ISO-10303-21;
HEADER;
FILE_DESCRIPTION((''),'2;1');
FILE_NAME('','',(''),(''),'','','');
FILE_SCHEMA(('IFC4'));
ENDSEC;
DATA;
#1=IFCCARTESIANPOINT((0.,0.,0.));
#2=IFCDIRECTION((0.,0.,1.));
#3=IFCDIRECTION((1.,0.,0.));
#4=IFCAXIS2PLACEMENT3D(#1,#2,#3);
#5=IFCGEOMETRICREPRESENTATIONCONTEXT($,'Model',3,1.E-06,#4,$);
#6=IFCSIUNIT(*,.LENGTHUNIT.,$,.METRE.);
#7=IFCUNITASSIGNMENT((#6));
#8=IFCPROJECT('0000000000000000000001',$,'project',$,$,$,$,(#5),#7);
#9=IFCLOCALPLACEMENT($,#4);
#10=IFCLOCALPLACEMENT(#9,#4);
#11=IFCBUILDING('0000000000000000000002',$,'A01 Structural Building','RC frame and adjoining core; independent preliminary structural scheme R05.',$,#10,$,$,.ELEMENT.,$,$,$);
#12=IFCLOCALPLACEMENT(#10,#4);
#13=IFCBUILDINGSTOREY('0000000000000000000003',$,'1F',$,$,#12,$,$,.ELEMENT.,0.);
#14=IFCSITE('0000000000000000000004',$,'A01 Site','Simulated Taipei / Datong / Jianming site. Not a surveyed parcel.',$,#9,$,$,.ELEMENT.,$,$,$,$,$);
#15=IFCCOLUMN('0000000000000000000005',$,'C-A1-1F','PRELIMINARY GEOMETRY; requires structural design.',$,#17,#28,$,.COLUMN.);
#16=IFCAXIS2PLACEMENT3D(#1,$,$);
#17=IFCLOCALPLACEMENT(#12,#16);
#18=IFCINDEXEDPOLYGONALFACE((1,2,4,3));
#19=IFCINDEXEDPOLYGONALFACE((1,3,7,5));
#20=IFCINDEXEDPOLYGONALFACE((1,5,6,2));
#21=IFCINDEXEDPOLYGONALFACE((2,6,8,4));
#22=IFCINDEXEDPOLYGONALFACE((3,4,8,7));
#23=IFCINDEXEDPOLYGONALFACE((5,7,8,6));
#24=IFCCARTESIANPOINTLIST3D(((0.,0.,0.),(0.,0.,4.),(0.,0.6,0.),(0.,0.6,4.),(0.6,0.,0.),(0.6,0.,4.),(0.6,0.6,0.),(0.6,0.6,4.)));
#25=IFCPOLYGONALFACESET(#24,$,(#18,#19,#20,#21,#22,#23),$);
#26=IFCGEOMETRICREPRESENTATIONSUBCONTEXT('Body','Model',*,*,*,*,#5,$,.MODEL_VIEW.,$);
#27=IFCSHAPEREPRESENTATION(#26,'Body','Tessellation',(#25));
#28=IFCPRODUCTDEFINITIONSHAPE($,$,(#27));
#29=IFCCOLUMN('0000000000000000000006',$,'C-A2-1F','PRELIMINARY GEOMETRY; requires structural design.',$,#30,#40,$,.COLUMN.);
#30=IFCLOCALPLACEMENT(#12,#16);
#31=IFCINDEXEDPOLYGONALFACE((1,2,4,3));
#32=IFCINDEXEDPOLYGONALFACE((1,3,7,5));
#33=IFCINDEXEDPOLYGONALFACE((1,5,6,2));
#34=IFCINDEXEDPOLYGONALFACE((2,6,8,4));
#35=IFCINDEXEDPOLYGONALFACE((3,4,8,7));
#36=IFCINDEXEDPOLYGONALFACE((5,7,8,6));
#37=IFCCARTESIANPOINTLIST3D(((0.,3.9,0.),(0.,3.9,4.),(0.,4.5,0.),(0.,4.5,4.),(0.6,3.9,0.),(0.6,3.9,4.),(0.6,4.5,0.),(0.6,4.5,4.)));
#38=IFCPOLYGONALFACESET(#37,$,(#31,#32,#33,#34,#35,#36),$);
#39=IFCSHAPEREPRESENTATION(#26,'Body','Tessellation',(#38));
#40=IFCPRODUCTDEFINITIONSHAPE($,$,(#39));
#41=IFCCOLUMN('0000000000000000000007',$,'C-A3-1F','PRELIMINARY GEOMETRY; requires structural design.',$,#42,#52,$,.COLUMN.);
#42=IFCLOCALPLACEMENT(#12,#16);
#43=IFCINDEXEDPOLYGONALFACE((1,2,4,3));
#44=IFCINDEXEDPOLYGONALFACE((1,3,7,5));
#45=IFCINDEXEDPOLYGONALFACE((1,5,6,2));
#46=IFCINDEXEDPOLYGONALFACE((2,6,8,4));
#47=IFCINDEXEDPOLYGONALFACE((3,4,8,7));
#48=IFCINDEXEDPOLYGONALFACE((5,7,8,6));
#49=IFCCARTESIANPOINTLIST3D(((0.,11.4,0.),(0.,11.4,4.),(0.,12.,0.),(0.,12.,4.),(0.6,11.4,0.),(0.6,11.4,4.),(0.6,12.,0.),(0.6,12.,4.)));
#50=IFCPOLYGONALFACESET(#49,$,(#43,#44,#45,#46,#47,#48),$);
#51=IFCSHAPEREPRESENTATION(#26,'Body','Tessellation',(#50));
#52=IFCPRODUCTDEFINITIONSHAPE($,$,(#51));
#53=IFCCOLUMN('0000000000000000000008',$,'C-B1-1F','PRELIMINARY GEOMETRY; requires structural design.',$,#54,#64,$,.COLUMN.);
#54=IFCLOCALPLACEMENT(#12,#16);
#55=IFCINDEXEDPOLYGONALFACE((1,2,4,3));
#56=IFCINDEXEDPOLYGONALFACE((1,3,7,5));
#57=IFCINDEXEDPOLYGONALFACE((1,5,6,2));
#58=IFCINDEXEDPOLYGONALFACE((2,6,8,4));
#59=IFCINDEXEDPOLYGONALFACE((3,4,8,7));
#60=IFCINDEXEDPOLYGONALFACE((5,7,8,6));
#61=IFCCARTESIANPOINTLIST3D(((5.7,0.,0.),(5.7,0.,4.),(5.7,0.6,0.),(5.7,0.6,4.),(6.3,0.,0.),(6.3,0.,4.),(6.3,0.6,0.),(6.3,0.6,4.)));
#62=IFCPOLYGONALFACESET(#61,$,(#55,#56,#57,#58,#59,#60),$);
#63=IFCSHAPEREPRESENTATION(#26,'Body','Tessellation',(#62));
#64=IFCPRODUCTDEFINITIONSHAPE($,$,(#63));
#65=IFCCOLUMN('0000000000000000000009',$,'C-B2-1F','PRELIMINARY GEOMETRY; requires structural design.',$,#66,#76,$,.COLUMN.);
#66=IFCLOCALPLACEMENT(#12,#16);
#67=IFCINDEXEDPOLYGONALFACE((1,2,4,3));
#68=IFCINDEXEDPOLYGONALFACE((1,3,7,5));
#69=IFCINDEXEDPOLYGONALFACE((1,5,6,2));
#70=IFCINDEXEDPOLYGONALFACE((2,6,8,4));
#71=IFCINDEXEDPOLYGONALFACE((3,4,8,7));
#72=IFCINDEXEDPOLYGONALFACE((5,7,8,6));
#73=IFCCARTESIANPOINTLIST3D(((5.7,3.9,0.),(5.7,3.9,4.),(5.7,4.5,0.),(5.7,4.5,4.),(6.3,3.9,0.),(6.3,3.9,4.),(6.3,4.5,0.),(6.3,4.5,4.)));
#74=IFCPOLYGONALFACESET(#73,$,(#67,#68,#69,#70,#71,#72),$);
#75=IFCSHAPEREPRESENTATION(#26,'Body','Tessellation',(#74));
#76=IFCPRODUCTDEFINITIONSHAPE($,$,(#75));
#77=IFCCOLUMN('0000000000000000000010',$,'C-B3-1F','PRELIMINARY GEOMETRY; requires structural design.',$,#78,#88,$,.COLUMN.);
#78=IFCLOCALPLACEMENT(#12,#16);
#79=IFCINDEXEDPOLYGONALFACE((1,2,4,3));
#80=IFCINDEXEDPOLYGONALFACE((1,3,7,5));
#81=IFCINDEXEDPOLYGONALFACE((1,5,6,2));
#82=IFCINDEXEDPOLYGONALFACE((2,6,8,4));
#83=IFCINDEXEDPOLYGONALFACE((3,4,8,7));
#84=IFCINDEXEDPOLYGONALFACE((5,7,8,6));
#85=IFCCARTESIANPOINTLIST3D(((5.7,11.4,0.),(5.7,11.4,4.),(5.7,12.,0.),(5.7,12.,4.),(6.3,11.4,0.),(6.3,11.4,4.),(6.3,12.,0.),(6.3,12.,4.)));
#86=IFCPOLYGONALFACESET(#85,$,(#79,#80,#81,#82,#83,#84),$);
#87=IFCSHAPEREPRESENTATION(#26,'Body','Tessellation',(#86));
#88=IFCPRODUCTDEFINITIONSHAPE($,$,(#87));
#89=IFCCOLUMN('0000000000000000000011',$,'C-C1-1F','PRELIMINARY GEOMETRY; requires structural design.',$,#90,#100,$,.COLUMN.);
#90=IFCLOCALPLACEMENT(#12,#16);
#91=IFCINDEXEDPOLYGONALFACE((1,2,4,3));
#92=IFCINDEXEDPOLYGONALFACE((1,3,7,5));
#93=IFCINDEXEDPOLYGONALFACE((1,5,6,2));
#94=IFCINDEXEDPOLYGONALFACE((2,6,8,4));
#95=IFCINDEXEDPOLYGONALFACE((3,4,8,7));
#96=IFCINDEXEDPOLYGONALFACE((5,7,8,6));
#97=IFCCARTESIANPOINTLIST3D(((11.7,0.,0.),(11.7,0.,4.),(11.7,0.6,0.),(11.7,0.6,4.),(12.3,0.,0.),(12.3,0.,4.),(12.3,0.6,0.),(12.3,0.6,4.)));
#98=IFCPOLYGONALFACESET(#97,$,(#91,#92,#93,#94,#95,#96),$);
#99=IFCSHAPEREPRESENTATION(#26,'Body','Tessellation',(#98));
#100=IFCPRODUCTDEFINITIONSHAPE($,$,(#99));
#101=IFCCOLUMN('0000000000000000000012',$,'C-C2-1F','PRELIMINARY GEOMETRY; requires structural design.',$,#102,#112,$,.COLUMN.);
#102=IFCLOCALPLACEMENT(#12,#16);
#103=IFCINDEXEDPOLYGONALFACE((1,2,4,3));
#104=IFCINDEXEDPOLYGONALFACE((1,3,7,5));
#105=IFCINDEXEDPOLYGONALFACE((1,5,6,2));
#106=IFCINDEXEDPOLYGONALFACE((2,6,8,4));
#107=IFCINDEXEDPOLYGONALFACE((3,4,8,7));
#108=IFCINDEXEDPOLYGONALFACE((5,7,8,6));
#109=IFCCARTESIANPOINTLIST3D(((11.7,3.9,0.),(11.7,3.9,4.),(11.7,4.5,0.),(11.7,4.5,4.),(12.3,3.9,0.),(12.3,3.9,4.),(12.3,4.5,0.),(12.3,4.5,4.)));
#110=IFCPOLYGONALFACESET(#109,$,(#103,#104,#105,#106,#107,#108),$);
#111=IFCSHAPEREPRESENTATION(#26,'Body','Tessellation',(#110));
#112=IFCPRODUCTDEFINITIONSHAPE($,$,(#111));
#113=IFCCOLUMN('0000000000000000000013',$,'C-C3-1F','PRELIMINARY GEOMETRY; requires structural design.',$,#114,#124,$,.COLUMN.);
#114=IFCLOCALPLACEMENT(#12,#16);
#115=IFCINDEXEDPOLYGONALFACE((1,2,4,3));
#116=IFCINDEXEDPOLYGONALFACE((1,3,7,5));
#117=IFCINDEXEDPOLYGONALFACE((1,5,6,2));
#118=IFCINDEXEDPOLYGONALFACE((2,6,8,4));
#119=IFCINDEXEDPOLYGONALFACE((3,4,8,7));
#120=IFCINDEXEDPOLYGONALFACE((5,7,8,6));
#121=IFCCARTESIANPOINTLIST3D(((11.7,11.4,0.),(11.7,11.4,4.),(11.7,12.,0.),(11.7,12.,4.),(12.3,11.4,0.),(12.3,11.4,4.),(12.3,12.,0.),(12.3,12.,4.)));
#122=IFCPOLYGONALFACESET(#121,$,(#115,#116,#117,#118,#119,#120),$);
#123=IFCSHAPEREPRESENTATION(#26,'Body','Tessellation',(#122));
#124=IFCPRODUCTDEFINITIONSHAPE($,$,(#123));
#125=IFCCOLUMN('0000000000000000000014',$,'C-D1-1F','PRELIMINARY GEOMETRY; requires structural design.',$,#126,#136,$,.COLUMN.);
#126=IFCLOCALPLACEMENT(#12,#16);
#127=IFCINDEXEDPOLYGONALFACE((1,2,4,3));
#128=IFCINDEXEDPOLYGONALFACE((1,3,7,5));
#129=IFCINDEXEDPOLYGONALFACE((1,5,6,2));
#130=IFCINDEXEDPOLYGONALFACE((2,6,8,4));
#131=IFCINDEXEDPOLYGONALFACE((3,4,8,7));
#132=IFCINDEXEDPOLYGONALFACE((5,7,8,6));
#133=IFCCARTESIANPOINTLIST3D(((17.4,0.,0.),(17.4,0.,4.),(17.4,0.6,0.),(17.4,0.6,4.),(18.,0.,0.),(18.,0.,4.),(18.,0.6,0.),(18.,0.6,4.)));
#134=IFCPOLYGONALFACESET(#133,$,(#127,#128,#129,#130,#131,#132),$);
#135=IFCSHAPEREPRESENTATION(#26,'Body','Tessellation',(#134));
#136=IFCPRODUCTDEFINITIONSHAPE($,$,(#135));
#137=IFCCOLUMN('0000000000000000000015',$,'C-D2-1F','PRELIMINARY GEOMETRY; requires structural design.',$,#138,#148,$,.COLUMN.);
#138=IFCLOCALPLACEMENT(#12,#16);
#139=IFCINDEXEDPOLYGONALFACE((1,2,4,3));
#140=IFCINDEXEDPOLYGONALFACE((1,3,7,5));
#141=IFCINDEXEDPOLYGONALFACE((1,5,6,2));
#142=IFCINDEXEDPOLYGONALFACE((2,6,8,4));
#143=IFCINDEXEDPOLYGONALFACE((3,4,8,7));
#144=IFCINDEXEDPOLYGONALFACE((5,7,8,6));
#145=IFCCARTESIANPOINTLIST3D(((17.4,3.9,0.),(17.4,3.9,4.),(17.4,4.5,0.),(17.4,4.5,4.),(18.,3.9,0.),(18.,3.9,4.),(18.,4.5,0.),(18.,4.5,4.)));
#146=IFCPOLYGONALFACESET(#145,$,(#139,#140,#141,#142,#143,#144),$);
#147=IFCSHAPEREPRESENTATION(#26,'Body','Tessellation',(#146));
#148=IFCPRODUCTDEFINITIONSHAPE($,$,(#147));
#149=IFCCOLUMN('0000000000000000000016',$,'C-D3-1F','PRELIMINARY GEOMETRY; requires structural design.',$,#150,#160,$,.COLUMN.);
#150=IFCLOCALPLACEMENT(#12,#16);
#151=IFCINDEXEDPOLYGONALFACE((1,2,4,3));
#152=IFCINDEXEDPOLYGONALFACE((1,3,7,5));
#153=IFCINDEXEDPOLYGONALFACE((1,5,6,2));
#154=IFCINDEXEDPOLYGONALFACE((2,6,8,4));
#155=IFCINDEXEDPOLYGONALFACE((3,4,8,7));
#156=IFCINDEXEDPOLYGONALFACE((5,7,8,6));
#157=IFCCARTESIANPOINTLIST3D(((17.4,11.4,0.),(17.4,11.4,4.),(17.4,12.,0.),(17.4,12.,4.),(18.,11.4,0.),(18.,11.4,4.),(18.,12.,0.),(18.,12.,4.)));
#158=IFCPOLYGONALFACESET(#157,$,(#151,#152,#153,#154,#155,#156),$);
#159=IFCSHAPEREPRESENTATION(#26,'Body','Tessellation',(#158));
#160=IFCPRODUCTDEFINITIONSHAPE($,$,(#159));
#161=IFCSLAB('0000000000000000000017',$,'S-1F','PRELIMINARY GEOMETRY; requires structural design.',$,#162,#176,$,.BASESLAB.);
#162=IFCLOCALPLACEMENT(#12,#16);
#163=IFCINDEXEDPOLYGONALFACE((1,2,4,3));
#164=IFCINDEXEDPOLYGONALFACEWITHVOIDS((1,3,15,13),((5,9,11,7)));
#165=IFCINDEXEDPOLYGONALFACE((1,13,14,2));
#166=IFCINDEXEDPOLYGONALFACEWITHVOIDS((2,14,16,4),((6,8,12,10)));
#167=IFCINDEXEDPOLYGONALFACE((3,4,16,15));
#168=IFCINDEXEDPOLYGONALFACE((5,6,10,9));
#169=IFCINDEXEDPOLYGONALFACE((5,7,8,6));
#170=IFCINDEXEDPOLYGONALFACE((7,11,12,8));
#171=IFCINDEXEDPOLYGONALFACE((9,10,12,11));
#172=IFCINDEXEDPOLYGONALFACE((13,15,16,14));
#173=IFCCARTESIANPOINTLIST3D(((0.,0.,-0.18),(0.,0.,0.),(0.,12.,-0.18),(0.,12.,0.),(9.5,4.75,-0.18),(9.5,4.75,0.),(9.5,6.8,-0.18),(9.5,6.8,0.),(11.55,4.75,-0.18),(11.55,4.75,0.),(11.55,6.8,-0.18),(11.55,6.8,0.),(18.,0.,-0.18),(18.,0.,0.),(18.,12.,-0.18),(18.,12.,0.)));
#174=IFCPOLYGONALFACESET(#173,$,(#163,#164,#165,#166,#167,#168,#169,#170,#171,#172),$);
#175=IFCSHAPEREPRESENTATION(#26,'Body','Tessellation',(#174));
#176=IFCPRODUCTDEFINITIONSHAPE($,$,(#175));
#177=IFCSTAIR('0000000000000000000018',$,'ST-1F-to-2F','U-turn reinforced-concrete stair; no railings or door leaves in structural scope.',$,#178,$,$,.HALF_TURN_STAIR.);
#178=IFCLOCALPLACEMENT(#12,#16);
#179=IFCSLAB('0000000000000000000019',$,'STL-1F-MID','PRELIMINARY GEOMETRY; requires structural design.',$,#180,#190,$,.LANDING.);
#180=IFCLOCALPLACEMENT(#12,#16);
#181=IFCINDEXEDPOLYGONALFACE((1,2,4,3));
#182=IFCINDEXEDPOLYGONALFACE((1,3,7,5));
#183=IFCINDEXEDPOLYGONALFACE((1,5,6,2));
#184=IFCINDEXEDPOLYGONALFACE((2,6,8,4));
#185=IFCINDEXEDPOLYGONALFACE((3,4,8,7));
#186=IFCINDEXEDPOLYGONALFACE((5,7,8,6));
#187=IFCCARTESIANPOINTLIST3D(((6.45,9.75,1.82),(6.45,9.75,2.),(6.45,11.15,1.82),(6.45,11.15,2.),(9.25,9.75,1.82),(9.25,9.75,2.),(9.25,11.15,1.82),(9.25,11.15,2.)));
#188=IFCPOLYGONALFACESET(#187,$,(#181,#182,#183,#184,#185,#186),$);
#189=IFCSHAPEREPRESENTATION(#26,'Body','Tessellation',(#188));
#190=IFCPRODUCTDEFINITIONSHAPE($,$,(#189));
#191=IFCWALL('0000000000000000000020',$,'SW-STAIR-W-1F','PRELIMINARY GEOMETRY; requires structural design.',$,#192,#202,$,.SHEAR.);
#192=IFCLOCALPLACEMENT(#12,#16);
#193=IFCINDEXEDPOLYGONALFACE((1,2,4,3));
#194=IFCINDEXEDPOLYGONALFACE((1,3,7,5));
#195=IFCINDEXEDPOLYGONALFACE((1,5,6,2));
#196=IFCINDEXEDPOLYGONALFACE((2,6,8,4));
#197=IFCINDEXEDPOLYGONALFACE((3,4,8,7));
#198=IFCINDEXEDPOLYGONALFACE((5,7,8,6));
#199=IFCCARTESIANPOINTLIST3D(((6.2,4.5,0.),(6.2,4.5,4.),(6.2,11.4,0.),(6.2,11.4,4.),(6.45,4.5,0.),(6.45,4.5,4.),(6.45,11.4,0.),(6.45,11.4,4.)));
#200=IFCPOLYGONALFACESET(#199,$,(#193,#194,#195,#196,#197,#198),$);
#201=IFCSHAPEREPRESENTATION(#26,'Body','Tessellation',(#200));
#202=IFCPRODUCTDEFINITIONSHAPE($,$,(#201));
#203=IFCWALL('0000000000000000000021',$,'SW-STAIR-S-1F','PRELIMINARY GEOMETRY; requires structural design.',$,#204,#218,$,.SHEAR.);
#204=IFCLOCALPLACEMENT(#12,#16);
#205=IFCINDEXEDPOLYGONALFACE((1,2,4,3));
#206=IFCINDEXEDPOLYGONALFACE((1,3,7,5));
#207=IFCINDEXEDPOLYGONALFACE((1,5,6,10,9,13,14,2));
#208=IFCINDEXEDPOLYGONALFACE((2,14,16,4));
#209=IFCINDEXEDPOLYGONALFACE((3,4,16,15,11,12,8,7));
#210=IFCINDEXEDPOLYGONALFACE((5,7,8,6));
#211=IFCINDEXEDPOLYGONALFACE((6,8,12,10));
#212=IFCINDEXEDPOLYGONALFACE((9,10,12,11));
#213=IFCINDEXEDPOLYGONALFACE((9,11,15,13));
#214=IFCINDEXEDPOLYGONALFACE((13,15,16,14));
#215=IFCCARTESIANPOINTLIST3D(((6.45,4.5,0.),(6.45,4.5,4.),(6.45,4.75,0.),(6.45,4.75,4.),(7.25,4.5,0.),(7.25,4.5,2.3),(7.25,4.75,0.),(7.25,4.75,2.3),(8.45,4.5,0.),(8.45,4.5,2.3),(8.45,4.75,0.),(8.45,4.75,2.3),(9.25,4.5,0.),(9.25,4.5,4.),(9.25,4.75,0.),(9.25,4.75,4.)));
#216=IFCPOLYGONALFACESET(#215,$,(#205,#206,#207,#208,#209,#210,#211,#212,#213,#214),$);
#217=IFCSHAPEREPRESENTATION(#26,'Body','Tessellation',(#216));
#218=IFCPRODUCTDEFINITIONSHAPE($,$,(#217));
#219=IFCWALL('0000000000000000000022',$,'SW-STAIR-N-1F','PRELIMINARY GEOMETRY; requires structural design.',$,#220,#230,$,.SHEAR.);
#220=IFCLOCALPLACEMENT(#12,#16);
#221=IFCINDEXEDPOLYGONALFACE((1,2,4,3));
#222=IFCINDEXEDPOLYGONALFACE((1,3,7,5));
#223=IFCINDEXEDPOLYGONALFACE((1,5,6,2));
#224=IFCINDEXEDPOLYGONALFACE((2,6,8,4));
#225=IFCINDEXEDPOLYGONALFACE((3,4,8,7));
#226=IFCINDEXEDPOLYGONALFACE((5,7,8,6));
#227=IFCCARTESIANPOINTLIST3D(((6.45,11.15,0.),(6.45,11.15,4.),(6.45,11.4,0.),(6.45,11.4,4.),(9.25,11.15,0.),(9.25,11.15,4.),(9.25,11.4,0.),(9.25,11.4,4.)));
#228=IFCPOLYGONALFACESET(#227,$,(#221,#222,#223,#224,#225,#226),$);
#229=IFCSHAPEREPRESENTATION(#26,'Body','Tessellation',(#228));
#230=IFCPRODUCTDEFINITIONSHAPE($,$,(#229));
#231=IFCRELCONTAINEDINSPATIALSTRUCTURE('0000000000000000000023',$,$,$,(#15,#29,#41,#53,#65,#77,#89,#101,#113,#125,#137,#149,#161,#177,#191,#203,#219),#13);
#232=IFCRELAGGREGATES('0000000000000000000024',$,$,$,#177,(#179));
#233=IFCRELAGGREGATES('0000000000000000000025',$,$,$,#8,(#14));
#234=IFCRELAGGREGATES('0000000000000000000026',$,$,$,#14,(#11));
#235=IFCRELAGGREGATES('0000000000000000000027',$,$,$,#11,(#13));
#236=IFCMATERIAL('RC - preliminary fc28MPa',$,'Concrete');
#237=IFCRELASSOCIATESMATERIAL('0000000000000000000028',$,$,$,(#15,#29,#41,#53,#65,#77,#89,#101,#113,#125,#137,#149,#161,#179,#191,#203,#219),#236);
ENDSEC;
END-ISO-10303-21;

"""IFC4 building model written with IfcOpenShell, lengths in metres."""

from ifc_helpers import new_model, si_unit, frame, origin_with_axes, place, context, subcontext, project, spatial, rectangle, extrude, material, element, aggregate, save


model = new_model("IFC4")

# Units and contexts
model_context = context("Model", 3, precision=1e-06, world=origin_with_axes())
body_context = subcontext(model_context, "Body", "Model", "MODEL_VIEW")
ifc_project = project(units=[si_unit("LENGTHUNIT", "METRE")], contexts=[model_context])

# Site, building, storey
site_placement = place(None, origin_with_axes())
site = spatial("IfcSite", under=ifc_project, at=site_placement, Name="A01 Site", Description="Simulated Taipei / Datong / Jianming site. Not a surveyed parcel.", CompositionType="ELEMENT")
building_placement = place(site_placement, origin_with_axes())
building = spatial("IfcBuilding", under=site, at=building_placement, Name="A01 Structural Building", Description="RC frame and adjoining core; independent preliminary structural scheme R05.", CompositionType="ELEMENT")
storey_placement = place(building_placement, origin_with_axes())
storey = spatial("IfcBuildingStorey", under=building, at=storey_placement, Name="1F", CompositionType="ELEMENT", Elevation=0.0)

# Columns
ifc_material = material(Name="RC - preliminary fc28MPa", Category="Concrete")
for number, where, z_axis, x_axis, name in (
    (1, (0.3, 0.3, 0.0), (0.0, 0.0, 1.0), (1.0, 0.0, 0.0), "C-A1-1F"),
    (2, (0.3, 4.2, 0.0), (0.0, 0.0, 1.0), (1.0, 0.0, 0.0), "C-A2-1F"),
    (3, (0.3, 11.7, 0.0), (0.0, 0.0, 1.0), (1.0, 0.0, 0.0), "C-A3-1F"),
    (4, (6.0, 0.3, 0.0), (0.0, 0.0, 1.0), (1.0, 0.0, 0.0), "C-B1-1F"),
    (5, (6.0, 4.2, 0.0), (0.0, 0.0, 1.0), (1.0, 0.0, 0.0), "C-B2-1F"),
    (6, (6.0, 11.7, 0.0), (0.0, 0.0, 1.0), (1.0, 0.0, 0.0), "C-B3-1F"),
    (7, (12.0, 0.3, 0.0), (0.0, 0.0, 1.0), (1.0, 0.0, 0.0), "C-C1-1F"),
    (8, (12.0, 4.2, 0.0), (0.0, 0.0, 1.0), (1.0, 0.0, 0.0), "C-C2-1F"),
    (9, (12.0, 11.7, 0.0), (0.0, 0.0, 1.0), (1.0, 0.0, 0.0), "C-C3-1F"),
    (10, (17.7, 0.3, 0.0), (0.0, 0.0, 1.0), (1.0, 0.0, 0.0), "C-D1-1F"),
    (11, (17.7, 4.2, 0.0), (0.0, 0.0, 1.0), (1.0, 0.0, 0.0), "C-D2-1F"),
    (12, (17.7, 11.7, 0.0), (0.0, 0.0, 1.0), (1.0, 0.0, 0.0), "C-D3-1F"),
):
    element("IfcColumn", number, at=place(storey_placement, frame(where, z_axis=z_axis, x_axis=x_axis)), inside=storey, material=ifc_material, Name=name, Description="PRELIMINARY GEOMETRY; requires structural design.", PredefinedType="COLUMN", context=body_context, shape_type="SweptSolid", body=[
        extrude(rectangle(XDim=0.6, YDim=0.6), origin_with_axes(), (0.0, 0.0, 1.0), 4.0),
    ])

# Slab, opening
slab_1_placement = place(storey_placement, frame((9.0, 6.0, -0.18), z_axis=(0.0, 0.0, 1.0), x_axis=(1.0, 0.0, 0.0)))
slab_1 = element("IfcSlab", 13, at=slab_1_placement, inside=storey, material=ifc_material, Name="S-1F", Description="PRELIMINARY GEOMETRY; requires structural design.", PredefinedType="BASESLAB", context=body_context, shape_type="SweptSolid", body=[
    extrude(rectangle(XDim=18.0, YDim=12.0), origin_with_axes(), (0.0, 0.0, 1.0), 0.18),
])
opening_1_placement = place(storey_placement, frame((10.525, 5.775, -0.23), z_axis=(0.0, 0.0, 1.0), x_axis=(1.0, 0.0, 0.0)))
element("IfcOpeningElement", 14, at=opening_1_placement, cuts=slab_1, PredefinedType="OPENING", context=body_context, shape_type="SweptSolid", body=[
    extrude(rectangle(XDim=2.05, YDim=2.05), origin_with_axes(), (0.0, 0.0, 1.0), 0.28),
])

# Stair, slab
stair_placement = place(storey_placement, origin_with_axes())
stair = element("IfcStair", 15, at=stair_placement, inside=storey, Name="ST-1F-to-2F", Description="U-turn reinforced-concrete stair; no railings or door leaves in structural scope.", PredefinedType="HALF_TURN_STAIR")
slab_2_placement = place(storey_placement, frame((7.85, 10.45, 1.82), z_axis=(0.0, 0.0, 1.0), x_axis=(1.0, 0.0, 0.0)))
slab_2 = element("IfcSlab", 16, at=slab_2_placement, material=ifc_material, Name="STL-1F-MID", Description="PRELIMINARY GEOMETRY; requires structural design.", PredefinedType="LANDING", context=body_context, shape_type="SweptSolid", body=[
    extrude(rectangle(XDim=2.8, YDim=1.4), origin_with_axes(), (0.0, 0.0, 1.0), 0.18),
])

# Wall
wall_1_placement = place(storey_placement, frame((6.325, 7.95, 0.0), z_axis=(0.0, 0.0, 1.0), x_axis=(1.0, 0.0, 0.0)))
element("IfcWall", 17, at=wall_1_placement, inside=storey, material=ifc_material, Name="SW-STAIR-W-1F", Description="PRELIMINARY GEOMETRY; requires structural design.", PredefinedType="SHEAR", context=body_context, shape_type="SweptSolid", body=[
    extrude(rectangle(XDim=0.25, YDim=6.9), origin_with_axes(), (0.0, 0.0, 1.0), 4.0),
])

# Wall, opening
wall_2_placement = place(storey_placement, frame((7.85, 4.625, 0.0), z_axis=(0.0, 0.0, 1.0), x_axis=(1.0, 0.0, 0.0)))
wall_2 = element("IfcWall", 18, at=wall_2_placement, inside=storey, material=ifc_material, Name="SW-STAIR-S-1F", Description="PRELIMINARY GEOMETRY; requires structural design.", PredefinedType="SHEAR", context=body_context, shape_type="SweptSolid", body=[
    extrude(rectangle(XDim=2.8, YDim=0.25), origin_with_axes(), (0.0, 0.0, 1.0), 4.0),
])
opening_2_placement = place(storey_placement, frame((7.85, 4.625, 0.0), z_axis=(0.0, 0.0, 1.0), x_axis=(1.0, 0.0, 0.0)))
element("IfcOpeningElement", 19, at=opening_2_placement, cuts=wall_2, PredefinedType="OPENING", context=body_context, shape_type="SweptSolid", body=[
    extrude(rectangle(XDim=1.2, YDim=0.45), origin_with_axes(), (0.0, 0.0, 1.0), 2.3),
])

# Wall
wall_3_placement = place(storey_placement, frame((7.85, 11.275, 0.0), z_axis=(0.0, 0.0, 1.0), x_axis=(1.0, 0.0, 0.0)))
element("IfcWall", 20, at=wall_3_placement, inside=storey, material=ifc_material, Name="SW-STAIR-N-1F", Description="PRELIMINARY GEOMETRY; requires structural design.", PredefinedType="SHEAR", context=body_context, shape_type="SweptSolid", body=[
    extrude(rectangle(XDim=2.8, YDim=0.25), origin_with_axes(), (0.0, 0.0, 1.0), 4.0),
])

aggregate(stair, [slab_2])

save(model, "model.ifc")
